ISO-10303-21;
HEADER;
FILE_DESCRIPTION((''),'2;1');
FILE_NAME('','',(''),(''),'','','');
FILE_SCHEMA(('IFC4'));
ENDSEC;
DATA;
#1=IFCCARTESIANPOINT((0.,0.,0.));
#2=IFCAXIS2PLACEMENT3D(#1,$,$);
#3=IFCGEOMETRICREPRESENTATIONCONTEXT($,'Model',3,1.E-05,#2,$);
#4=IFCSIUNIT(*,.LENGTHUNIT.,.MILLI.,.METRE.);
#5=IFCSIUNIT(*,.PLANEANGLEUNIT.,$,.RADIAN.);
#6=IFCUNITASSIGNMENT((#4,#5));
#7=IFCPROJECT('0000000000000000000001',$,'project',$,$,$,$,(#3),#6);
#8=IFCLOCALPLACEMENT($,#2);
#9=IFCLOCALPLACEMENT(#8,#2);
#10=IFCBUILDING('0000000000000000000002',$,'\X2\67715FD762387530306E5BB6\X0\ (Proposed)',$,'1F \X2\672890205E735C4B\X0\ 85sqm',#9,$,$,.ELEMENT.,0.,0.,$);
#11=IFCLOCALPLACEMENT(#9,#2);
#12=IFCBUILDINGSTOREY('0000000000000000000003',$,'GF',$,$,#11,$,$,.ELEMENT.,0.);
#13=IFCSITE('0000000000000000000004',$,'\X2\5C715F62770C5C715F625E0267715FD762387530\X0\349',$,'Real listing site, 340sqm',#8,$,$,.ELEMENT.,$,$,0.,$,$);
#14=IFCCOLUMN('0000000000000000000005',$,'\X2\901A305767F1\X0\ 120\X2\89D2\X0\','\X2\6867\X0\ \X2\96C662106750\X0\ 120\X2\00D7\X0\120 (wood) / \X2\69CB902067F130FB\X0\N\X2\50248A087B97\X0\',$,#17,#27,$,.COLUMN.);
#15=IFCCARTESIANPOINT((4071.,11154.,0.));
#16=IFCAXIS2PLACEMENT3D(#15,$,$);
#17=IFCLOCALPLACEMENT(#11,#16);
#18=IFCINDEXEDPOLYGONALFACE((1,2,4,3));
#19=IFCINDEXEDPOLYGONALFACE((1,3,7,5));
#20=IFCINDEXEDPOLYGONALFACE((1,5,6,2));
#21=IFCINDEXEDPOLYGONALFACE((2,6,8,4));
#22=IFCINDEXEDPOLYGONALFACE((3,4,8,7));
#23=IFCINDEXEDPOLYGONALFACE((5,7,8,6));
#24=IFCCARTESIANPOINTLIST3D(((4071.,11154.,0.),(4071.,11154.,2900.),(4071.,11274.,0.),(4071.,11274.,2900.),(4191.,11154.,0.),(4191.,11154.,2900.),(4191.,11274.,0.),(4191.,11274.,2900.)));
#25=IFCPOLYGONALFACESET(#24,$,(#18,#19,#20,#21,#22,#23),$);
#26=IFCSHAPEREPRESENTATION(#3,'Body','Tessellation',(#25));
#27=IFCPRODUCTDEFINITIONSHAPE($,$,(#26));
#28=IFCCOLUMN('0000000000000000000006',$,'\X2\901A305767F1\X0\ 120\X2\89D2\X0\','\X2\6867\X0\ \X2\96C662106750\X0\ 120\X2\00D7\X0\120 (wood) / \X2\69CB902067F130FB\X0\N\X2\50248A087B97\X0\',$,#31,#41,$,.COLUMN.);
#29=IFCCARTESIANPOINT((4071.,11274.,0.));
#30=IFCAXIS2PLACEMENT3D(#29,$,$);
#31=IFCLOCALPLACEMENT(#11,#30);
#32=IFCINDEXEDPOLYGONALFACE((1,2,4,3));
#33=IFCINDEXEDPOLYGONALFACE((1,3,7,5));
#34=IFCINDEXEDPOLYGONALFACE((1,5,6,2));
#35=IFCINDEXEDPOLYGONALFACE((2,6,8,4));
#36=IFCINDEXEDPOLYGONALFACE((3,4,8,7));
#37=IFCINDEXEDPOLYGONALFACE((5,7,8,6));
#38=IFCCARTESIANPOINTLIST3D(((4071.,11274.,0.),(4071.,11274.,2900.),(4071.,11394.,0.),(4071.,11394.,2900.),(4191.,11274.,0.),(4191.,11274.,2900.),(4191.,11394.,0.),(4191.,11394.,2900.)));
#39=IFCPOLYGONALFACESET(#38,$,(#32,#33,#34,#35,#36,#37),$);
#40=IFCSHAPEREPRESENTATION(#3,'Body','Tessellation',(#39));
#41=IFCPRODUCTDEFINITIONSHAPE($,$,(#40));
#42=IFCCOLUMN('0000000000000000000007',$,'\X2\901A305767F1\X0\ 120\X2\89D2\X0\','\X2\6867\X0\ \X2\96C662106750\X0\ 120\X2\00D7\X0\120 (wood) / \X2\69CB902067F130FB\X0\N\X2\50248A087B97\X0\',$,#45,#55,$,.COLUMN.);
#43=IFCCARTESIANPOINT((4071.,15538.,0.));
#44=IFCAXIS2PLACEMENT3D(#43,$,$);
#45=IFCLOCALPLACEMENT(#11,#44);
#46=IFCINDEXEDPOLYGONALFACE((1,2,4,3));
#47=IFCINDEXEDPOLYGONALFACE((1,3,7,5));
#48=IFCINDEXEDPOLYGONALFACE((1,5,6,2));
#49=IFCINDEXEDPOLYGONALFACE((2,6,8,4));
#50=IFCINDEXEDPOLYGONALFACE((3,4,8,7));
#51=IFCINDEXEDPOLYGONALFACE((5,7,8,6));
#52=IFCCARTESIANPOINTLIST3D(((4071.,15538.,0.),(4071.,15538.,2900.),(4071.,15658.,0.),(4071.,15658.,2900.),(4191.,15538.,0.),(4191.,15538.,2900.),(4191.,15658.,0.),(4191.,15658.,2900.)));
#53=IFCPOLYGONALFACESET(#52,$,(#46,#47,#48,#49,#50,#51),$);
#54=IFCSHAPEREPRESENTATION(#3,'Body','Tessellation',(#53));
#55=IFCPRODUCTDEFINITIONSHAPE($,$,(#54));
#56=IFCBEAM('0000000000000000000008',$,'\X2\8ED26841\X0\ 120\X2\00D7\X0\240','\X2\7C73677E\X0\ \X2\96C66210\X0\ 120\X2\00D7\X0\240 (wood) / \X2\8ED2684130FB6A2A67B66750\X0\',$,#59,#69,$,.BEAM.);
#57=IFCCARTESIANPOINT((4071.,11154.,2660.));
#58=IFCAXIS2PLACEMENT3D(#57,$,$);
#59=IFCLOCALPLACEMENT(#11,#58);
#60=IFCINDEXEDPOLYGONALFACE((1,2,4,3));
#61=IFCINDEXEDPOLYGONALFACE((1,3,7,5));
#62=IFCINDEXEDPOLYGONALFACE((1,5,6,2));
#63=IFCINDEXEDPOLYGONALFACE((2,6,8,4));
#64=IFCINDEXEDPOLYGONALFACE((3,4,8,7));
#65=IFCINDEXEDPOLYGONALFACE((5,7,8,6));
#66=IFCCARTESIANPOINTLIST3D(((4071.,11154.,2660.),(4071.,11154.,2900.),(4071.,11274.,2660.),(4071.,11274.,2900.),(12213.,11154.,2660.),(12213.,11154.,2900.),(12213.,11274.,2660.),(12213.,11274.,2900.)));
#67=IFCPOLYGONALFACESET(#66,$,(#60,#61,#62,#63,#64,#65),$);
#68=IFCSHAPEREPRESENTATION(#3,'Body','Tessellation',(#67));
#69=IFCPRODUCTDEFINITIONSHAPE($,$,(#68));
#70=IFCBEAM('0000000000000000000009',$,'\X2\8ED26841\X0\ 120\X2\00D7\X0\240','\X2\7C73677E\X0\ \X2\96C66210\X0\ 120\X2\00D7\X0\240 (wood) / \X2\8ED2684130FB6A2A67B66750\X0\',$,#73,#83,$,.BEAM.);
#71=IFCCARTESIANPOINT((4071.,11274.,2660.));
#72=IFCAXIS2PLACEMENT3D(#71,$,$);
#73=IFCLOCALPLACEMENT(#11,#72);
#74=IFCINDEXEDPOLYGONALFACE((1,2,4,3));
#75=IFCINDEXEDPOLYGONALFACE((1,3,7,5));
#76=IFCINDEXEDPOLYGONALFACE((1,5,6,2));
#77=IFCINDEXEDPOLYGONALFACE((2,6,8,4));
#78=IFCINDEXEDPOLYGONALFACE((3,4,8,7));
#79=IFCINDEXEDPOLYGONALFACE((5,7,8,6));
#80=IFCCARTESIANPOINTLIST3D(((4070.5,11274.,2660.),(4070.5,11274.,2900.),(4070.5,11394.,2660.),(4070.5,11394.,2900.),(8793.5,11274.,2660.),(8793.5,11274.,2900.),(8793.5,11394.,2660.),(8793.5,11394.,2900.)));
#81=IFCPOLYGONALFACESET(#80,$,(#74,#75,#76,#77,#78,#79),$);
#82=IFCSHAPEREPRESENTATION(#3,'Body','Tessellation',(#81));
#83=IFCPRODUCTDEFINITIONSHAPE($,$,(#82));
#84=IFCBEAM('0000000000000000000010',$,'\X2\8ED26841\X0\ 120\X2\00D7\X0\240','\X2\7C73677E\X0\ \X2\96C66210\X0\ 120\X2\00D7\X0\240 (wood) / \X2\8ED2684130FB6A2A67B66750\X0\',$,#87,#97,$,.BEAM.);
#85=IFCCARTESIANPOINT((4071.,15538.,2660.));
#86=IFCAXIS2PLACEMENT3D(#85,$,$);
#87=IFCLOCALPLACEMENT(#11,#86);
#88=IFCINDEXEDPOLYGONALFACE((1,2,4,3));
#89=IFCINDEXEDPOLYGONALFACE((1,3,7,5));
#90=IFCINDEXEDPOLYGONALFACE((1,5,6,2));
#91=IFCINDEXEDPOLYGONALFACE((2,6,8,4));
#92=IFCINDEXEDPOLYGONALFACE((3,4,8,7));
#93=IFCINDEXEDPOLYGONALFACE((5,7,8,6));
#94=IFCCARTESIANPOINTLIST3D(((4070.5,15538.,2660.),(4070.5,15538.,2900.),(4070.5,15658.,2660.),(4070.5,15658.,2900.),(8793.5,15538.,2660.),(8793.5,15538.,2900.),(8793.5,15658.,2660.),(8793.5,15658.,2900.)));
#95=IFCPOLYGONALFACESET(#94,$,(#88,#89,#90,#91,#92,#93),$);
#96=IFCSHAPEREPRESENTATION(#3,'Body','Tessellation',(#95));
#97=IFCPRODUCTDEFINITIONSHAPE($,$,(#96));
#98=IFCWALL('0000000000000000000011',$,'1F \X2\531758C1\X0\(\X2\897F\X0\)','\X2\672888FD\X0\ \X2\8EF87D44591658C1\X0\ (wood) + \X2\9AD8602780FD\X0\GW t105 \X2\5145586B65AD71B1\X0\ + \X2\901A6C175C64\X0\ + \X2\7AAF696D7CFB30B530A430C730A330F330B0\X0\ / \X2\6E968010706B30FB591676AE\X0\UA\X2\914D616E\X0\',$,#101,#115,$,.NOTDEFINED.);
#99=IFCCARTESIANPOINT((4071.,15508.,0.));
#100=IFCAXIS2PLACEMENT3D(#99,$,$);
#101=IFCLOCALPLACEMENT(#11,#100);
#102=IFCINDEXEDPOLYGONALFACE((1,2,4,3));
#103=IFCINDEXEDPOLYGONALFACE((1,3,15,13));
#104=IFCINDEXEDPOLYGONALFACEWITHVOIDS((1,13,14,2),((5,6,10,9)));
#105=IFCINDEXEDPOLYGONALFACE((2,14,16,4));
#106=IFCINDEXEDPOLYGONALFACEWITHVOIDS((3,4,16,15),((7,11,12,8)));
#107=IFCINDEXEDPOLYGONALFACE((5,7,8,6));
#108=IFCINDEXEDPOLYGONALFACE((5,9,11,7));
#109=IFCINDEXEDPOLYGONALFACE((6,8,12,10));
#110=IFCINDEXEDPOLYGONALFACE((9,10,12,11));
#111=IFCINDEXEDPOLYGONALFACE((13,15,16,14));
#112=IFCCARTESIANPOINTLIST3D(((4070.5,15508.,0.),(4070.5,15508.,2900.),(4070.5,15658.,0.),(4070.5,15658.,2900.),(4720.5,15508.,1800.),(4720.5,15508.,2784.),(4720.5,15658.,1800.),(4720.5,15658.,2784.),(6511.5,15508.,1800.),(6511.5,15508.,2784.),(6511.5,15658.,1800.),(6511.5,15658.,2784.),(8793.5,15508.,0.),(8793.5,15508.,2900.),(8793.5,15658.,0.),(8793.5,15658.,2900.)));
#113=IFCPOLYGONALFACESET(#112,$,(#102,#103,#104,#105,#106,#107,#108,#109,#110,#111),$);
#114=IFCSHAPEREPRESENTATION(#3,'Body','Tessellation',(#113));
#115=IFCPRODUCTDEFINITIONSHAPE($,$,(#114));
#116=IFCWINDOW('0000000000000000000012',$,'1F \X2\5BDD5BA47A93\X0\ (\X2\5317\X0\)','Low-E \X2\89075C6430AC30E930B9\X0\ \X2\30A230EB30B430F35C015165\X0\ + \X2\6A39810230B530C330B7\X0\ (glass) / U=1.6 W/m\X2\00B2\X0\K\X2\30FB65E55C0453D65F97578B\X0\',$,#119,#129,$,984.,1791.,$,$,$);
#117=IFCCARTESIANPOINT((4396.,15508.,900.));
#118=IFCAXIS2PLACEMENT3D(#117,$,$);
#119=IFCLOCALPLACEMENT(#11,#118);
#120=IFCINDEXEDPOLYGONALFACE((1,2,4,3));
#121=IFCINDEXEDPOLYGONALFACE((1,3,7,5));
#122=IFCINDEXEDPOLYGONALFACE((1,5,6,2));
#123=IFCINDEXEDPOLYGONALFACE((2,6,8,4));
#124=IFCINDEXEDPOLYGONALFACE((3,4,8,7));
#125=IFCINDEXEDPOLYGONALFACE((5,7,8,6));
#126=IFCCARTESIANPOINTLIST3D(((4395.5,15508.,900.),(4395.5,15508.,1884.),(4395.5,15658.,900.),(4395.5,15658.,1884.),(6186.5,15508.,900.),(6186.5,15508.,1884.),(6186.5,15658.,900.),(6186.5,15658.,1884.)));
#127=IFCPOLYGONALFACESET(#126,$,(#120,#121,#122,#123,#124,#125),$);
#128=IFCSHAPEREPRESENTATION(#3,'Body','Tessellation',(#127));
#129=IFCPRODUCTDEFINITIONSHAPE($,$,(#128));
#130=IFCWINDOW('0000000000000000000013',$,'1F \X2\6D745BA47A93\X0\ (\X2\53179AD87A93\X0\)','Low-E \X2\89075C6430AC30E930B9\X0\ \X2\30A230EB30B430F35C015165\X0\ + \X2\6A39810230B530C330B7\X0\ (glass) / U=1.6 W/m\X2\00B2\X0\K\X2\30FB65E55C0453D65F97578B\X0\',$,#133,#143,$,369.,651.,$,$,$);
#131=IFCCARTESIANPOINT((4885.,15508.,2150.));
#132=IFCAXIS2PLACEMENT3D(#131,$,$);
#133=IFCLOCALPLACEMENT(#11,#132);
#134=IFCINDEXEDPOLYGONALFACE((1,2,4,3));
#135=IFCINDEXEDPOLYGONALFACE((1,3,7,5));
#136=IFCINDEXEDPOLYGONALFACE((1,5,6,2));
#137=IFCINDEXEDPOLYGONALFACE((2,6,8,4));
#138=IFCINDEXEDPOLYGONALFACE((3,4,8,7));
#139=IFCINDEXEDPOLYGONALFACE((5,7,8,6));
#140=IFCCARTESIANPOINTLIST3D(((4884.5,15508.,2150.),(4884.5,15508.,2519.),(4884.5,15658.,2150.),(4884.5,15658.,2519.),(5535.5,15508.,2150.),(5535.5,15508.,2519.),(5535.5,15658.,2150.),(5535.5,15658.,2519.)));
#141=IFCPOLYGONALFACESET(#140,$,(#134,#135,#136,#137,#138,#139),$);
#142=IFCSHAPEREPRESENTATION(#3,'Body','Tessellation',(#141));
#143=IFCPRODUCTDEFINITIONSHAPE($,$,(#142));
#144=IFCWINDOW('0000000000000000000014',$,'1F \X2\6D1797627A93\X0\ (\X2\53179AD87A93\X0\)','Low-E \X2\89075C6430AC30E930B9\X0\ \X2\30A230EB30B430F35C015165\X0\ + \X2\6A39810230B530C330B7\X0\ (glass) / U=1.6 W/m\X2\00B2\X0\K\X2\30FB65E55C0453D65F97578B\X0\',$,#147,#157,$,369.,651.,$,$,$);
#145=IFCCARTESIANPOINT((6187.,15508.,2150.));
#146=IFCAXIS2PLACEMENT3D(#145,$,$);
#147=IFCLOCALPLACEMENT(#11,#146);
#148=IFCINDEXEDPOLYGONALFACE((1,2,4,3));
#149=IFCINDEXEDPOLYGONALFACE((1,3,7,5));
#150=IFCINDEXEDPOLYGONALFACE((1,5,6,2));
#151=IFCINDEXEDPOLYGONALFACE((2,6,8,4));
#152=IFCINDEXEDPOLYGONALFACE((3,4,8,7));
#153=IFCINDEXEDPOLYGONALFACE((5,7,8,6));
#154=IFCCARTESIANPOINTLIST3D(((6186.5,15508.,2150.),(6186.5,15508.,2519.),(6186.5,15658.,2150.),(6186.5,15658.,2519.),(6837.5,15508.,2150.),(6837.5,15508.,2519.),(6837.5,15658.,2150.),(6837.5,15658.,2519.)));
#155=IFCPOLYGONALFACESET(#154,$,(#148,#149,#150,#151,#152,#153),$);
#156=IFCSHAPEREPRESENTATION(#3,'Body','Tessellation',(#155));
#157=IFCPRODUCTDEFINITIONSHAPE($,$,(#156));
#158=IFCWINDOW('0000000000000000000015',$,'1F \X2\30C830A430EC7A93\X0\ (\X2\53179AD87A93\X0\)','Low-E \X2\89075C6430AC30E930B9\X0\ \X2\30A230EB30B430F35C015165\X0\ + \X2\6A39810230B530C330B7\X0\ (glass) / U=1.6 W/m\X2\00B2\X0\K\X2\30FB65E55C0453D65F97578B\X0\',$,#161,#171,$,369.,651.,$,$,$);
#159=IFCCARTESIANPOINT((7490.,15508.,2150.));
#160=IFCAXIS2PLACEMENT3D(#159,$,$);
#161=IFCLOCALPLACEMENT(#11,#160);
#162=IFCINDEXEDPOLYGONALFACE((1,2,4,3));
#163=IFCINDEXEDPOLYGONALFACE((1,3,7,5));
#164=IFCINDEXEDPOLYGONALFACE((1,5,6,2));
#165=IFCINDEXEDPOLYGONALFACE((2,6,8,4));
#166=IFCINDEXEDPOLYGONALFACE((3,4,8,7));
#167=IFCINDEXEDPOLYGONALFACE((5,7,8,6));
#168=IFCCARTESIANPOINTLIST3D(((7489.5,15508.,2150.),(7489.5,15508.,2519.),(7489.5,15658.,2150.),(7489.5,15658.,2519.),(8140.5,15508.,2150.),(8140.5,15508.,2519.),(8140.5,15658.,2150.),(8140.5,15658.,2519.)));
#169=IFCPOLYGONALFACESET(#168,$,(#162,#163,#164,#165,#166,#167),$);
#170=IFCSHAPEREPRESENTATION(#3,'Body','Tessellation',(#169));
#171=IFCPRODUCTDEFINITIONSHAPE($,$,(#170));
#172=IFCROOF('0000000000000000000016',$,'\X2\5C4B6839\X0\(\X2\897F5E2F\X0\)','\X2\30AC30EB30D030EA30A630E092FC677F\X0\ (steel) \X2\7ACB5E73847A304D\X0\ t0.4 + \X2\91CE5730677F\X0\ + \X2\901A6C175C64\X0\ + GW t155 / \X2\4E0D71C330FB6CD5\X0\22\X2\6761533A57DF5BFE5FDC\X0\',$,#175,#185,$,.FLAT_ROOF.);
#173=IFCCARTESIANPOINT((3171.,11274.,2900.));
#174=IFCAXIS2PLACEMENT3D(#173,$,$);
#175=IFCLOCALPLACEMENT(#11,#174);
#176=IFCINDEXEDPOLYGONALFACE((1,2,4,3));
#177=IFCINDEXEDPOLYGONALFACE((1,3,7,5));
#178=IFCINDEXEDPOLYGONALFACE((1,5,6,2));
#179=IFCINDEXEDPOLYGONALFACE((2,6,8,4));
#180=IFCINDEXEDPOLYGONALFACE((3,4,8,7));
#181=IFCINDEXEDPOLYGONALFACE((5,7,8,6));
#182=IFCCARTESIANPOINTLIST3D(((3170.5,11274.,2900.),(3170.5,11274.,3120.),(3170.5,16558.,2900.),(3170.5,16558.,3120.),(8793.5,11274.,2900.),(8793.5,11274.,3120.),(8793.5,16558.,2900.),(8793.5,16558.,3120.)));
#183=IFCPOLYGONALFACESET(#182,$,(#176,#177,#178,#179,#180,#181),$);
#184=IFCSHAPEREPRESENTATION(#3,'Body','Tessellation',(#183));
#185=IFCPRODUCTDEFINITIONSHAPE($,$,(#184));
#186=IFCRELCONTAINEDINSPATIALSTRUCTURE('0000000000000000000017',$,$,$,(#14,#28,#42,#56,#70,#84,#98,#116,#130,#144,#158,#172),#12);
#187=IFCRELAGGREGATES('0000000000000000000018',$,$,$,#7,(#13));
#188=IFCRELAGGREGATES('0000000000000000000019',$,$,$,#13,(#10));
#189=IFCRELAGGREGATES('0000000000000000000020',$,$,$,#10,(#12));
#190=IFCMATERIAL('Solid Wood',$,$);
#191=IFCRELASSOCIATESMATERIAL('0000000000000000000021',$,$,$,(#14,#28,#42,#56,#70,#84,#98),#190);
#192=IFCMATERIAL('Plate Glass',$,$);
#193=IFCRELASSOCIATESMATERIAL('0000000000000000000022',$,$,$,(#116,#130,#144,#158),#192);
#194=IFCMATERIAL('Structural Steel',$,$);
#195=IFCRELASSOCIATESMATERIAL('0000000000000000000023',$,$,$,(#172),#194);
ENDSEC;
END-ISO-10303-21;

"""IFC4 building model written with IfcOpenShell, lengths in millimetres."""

from ifc_helpers import new_model, si_unit, frame, frame_2d, origin, place, context, project, spatial, rectangle, extrude, material, element, fill, save


model = new_model("IFC4")

# Units and contexts
model_context = context("Model", 3, precision=1e-05, world=origin())
ifc_project = project(units=[si_unit("LENGTHUNIT", "METRE", prefix="MILLI"), si_unit("PLANEANGLEUNIT", "RADIAN")], contexts=[model_context])

# Site, building, storey
site_placement = place(None, origin())
site = spatial("IfcSite", under=ifc_project, at=site_placement, Name="山形県山形市東志戸田349", ObjectType="Real listing site, 340sqm", CompositionType="ELEMENT", RefElevation=0.0)
building_placement = place(site_placement, origin())
building = spatial("IfcBuilding", under=site, at=building_placement, Name="東志戸田の家 (Proposed)", ObjectType="1F 木造平屋 85sqm", CompositionType="ELEMENT", ElevationOfRefHeight=0.0, ElevationOfTerrain=0.0)
storey_placement = place(building_placement, origin())
storey = spatial("IfcBuildingStorey", under=building, at=storey_placement, Name="GF", CompositionType="ELEMENT", Elevation=0.0)

# Columns
ifc_material_1 = material(Name="Solid Wood")
column_1_placement = place(storey_placement, frame((4071.0, 11154.0, 0.0)))
element("IfcColumn", 1, at=column_1_placement, inside=storey, material=ifc_material_1, Name="通し柱 120角", Description="桧 集成材 120×120 (wood) / 構造柱・N値計算", PredefinedType="COLUMN", context=model_context, shape_type="SweptSolid", body=[
    extrude(rectangle(XDim=120.0, YDim=120.0, at=frame_2d((60.0, 60.0))), frame((4071.0, 11154.0, 0.0)), (0.0, 0.0, 1.0), 2900.0),
])
column_2_placement = place(storey_placement, frame((4071.0, 11274.0, 0.0)))
element("IfcColumn", 2, at=column_2_placement, inside=storey, material=ifc_material_1, Name="通し柱 120角", Description="桧 集成材 120×120 (wood) / 構造柱・N値計算", PredefinedType="COLUMN", context=model_context, shape_type="SweptSolid", body=[
    extrude(rectangle(XDim=120.0, YDim=120.0, at=frame_2d((60.0, 60.0))), frame((4071.0, 11274.0, 0.0)), (0.0, 0.0, 1.0), 2900.0),
])
column_3_placement = place(storey_placement, frame((4071.0, 15538.0, 0.0)))
element("IfcColumn", 3, at=column_3_placement, inside=storey, material=ifc_material_1, Name="通し柱 120角", Description="桧 集成材 120×120 (wood) / 構造柱・N値計算", PredefinedType="COLUMN", context=model_context, shape_type="SweptSolid", body=[
    extrude(rectangle(XDim=120.0, YDim=120.0, at=frame_2d((60.0, 60.0))), frame((4071.0, 15538.0, 0.0)), (0.0, 0.0, 1.0), 2900.0),
])

# Beams
beam_1_placement = place(storey_placement, frame((4071.0, 11154.0, 2660.0)))
element("IfcBeam", 4, at=beam_1_placement, inside=storey, material=ifc_material_1, Name="軒桁 120×240", Description="米松 集成 120×240 (wood) / 軒桁・横架材", PredefinedType="BEAM", context=model_context, shape_type="SweptSolid", body=[
    extrude(rectangle(XDim=8142.0, YDim=120.0, at=frame_2d((4071.0, 60.0))), frame((4071.0, 11154.0, 2660.0)), (0.0, 0.0, 1.0), 240.0),
])
beam_2_placement = place(storey_placement, frame((4071.0, 11274.0, 2660.0)))
element("IfcBeam", 5, at=beam_2_placement, inside=storey, material=ifc_material_1, Name="軒桁 120×240", Description="米松 集成 120×240 (wood) / 軒桁・横架材", PredefinedType="BEAM", context=model_context, shape_type="SweptSolid", body=[
    extrude(rectangle(XDim=4723.0, YDim=120.0, at=frame_2d((2361.0, 60.0))), frame((4071.0, 11274.0, 2660.0)), (0.0, 0.0, 1.0), 240.0),
])
beam_3_placement = place(storey_placement, frame((4071.0, 15538.0, 2660.0)))
element("IfcBeam", 6, at=beam_3_placement, inside=storey, material=ifc_material_1, Name="軒桁 120×240", Description="米松 集成 120×240 (wood) / 軒桁・横架材", PredefinedType="BEAM", context=model_context, shape_type="SweptSolid", body=[
    extrude(rectangle(XDim=4723.0, YDim=120.0, at=frame_2d((2361.0, 60.0))), frame((4071.0, 15538.0, 2660.0)), (0.0, 0.0, 1.0), 240.0),
])

# Wall, openings, windows
wall_1_placement = place(storey_placement, frame((4071.0, 15508.0, 0.0)))
wall_1 = element("IfcWall", 7, at=wall_1_placement, inside=storey, material=ifc_material_1, Name="1F 北壁(西)", Description="木製 軸組外壁 (wood) + 高性能GW t105 充填断熱 + 通気層 + 窯業系サイディング / 準耐火・外皮UA配慮", PredefinedType="NOTDEFINED", context=model_context, shape_type="SweptSolid", body=[
    extrude(rectangle(XDim=4723.0, YDim=150.0, at=frame_2d((2361.0, 75.0))), frame((4071.0, 15508.0, 0.0)), (0.0, 0.0, 1.0), 2900.0),
])
opening_1_placement = place(storey_placement, frame((4396.0, 15508.0, 900.0)))
opening_1 = element("IfcOpeningElement", 8, at=opening_1_placement, cuts=wall_1, PredefinedType="NOTDEFINED", context=model_context, shape_type="SweptSolid", body=[
    extrude(rectangle(XDim=1791.0, YDim=150.0, at=frame_2d((895.0, 75.0))), frame((4396.0, 15508.0, 900.0)), (0.0, 0.0, 1.0), 984.0),
])
opening_2_placement = place(storey_placement, frame((4885.0, 15508.0, 2150.0)))
opening_2 = element("IfcOpeningElement", 9, at=opening_2_placement, cuts=wall_1, PredefinedType="NOTDEFINED", context=model_context, shape_type="SweptSolid", body=[
    extrude(rectangle(XDim=651.0, YDim=150.0, at=frame_2d((325.0, 75.0))), frame((4885.0, 15508.0, 2150.0)), (0.0, 0.0, 1.0), 369.0),
])
opening_3_placement = place(storey_placement, frame((6187.0, 15508.0, 2150.0)))
opening_3 = element("IfcOpeningElement", 10, at=opening_3_placement, cuts=wall_1, PredefinedType="NOTDEFINED", context=model_context, shape_type="SweptSolid", body=[
    extrude(rectangle(XDim=651.0, YDim=150.0, at=frame_2d((325.0, 75.0))), frame((6187.0, 15508.0, 2150.0)), (0.0, 0.0, 1.0), 369.0),
])
opening_4_placement = place(storey_placement, frame((7490.0, 15508.0, 2150.0)))
opening_4 = element("IfcOpeningElement", 11, at=opening_4_placement, cuts=wall_1, PredefinedType="NOTDEFINED", context=model_context, shape_type="SweptSolid", body=[
    extrude(rectangle(XDim=651.0, YDim=150.0, at=frame_2d((325.0, 75.0))), frame((7490.0, 15508.0, 2150.0)), (0.0, 0.0, 1.0), 369.0),
])
ifc_material_2 = material(Name="Plate Glass")
window_1_placement = place(storey_placement, frame((4396.0, 15508.0, 900.0)))
window_1 = element("IfcWindow", 12, at=window_1_placement, inside=storey, material=ifc_material_2, Name="1F 寝室窓 (北)", Description="Low-E 複層ガラス アルゴン封入 + 樹脂サッシ (glass) / U=1.6 W/m²K・日射取得型", OverallHeight=984.0, OverallWidth=1791.0, context=model_context, shape_type="SweptSolid", body=[
    extrude(rectangle(XDim=1791.0, YDim=150.0, at=frame_2d((895.0, 75.0))), frame((4396.0, 15508.0, 900.0)), (0.0, 0.0, 1.0), 984.0),
])
fill(opening_1, window_1)
window_2_placement = place(storey_placement, frame((4885.0, 15508.0, 2150.0)))
window_2 = element("IfcWindow", 13, at=window_2_placement, inside=storey, material=ifc_material_2, Name="1F 浴室窓 (北高窓)", Description="Low-E 複層ガラス アルゴン封入 + 樹脂サッシ (glass) / U=1.6 W/m²K・日射取得型", OverallHeight=369.0, OverallWidth=651.0, context=model_context, shape_type="SweptSolid", body=[
    extrude(rectangle(XDim=651.0, YDim=150.0, at=frame_2d((325.0, 75.0))), frame((4885.0, 15508.0, 2150.0)), (0.0, 0.0, 1.0), 369.0),
])
fill(opening_2, window_2)
window_3_placement = place(storey_placement, frame((6187.0, 15508.0, 2150.0)))
window_3 = element("IfcWindow", 14, at=window_3_placement, inside=storey, material=ifc_material_2, Name="1F 洗面窓 (北高窓)", Description="Low-E 複層ガラス アルゴン封入 + 樹脂サッシ (glass) / U=1.6 W/m²K・日射取得型", OverallHeight=369.0, OverallWidth=651.0, context=model_context, shape_type="SweptSolid", body=[
    extrude(rectangle(XDim=651.0, YDim=150.0, at=frame_2d((325.0, 75.0))), frame((6187.0, 15508.0, 2150.0)), (0.0, 0.0, 1.0), 369.0),
])
fill(opening_3, window_3)
window_4_placement = place(storey_placement, frame((7490.0, 15508.0, 2150.0)))
window_4 = element("IfcWindow", 15, at=window_4_placement, inside=storey, material=ifc_material_2, Name="1F トイレ窓 (北高窓)", Description="Low-E 複層ガラス アルゴン封入 + 樹脂サッシ (glass) / U=1.6 W/m²K・日射取得型", OverallHeight=369.0, OverallWidth=651.0, context=model_context, shape_type="SweptSolid", body=[
    extrude(rectangle(XDim=651.0, YDim=150.0, at=frame_2d((325.0, 75.0))), frame((7490.0, 15508.0, 2150.0)), (0.0, 0.0, 1.0), 369.0),
])
fill(opening_4, window_4)

# Roof
ifc_material_3 = material(Name="Structural Steel")
roof_placement = place(storey_placement, frame((3171.0, 11274.0, 2900.0)))
element("IfcRoof", 16, at=roof_placement, inside=storey, material=ifc_material_3, Name="屋根(西帯)", Description="ガルバリウム鋼板 (steel) 立平葺き t0.4 + 野地板 + 通気層 + GW t155 / 不燃・法22条区域対応", PredefinedType="FLAT_ROOF", context=model_context, shape_type="SweptSolid", body=[
    extrude(rectangle(XDim=5623.0, YDim=5284.0, at=frame_2d((2811.0, 2642.0))), frame((3171.0, 11274.0, 2900.0)), (0.0, 0.0, 1.0), 220.0),
])

save(model, "model.ifc")
